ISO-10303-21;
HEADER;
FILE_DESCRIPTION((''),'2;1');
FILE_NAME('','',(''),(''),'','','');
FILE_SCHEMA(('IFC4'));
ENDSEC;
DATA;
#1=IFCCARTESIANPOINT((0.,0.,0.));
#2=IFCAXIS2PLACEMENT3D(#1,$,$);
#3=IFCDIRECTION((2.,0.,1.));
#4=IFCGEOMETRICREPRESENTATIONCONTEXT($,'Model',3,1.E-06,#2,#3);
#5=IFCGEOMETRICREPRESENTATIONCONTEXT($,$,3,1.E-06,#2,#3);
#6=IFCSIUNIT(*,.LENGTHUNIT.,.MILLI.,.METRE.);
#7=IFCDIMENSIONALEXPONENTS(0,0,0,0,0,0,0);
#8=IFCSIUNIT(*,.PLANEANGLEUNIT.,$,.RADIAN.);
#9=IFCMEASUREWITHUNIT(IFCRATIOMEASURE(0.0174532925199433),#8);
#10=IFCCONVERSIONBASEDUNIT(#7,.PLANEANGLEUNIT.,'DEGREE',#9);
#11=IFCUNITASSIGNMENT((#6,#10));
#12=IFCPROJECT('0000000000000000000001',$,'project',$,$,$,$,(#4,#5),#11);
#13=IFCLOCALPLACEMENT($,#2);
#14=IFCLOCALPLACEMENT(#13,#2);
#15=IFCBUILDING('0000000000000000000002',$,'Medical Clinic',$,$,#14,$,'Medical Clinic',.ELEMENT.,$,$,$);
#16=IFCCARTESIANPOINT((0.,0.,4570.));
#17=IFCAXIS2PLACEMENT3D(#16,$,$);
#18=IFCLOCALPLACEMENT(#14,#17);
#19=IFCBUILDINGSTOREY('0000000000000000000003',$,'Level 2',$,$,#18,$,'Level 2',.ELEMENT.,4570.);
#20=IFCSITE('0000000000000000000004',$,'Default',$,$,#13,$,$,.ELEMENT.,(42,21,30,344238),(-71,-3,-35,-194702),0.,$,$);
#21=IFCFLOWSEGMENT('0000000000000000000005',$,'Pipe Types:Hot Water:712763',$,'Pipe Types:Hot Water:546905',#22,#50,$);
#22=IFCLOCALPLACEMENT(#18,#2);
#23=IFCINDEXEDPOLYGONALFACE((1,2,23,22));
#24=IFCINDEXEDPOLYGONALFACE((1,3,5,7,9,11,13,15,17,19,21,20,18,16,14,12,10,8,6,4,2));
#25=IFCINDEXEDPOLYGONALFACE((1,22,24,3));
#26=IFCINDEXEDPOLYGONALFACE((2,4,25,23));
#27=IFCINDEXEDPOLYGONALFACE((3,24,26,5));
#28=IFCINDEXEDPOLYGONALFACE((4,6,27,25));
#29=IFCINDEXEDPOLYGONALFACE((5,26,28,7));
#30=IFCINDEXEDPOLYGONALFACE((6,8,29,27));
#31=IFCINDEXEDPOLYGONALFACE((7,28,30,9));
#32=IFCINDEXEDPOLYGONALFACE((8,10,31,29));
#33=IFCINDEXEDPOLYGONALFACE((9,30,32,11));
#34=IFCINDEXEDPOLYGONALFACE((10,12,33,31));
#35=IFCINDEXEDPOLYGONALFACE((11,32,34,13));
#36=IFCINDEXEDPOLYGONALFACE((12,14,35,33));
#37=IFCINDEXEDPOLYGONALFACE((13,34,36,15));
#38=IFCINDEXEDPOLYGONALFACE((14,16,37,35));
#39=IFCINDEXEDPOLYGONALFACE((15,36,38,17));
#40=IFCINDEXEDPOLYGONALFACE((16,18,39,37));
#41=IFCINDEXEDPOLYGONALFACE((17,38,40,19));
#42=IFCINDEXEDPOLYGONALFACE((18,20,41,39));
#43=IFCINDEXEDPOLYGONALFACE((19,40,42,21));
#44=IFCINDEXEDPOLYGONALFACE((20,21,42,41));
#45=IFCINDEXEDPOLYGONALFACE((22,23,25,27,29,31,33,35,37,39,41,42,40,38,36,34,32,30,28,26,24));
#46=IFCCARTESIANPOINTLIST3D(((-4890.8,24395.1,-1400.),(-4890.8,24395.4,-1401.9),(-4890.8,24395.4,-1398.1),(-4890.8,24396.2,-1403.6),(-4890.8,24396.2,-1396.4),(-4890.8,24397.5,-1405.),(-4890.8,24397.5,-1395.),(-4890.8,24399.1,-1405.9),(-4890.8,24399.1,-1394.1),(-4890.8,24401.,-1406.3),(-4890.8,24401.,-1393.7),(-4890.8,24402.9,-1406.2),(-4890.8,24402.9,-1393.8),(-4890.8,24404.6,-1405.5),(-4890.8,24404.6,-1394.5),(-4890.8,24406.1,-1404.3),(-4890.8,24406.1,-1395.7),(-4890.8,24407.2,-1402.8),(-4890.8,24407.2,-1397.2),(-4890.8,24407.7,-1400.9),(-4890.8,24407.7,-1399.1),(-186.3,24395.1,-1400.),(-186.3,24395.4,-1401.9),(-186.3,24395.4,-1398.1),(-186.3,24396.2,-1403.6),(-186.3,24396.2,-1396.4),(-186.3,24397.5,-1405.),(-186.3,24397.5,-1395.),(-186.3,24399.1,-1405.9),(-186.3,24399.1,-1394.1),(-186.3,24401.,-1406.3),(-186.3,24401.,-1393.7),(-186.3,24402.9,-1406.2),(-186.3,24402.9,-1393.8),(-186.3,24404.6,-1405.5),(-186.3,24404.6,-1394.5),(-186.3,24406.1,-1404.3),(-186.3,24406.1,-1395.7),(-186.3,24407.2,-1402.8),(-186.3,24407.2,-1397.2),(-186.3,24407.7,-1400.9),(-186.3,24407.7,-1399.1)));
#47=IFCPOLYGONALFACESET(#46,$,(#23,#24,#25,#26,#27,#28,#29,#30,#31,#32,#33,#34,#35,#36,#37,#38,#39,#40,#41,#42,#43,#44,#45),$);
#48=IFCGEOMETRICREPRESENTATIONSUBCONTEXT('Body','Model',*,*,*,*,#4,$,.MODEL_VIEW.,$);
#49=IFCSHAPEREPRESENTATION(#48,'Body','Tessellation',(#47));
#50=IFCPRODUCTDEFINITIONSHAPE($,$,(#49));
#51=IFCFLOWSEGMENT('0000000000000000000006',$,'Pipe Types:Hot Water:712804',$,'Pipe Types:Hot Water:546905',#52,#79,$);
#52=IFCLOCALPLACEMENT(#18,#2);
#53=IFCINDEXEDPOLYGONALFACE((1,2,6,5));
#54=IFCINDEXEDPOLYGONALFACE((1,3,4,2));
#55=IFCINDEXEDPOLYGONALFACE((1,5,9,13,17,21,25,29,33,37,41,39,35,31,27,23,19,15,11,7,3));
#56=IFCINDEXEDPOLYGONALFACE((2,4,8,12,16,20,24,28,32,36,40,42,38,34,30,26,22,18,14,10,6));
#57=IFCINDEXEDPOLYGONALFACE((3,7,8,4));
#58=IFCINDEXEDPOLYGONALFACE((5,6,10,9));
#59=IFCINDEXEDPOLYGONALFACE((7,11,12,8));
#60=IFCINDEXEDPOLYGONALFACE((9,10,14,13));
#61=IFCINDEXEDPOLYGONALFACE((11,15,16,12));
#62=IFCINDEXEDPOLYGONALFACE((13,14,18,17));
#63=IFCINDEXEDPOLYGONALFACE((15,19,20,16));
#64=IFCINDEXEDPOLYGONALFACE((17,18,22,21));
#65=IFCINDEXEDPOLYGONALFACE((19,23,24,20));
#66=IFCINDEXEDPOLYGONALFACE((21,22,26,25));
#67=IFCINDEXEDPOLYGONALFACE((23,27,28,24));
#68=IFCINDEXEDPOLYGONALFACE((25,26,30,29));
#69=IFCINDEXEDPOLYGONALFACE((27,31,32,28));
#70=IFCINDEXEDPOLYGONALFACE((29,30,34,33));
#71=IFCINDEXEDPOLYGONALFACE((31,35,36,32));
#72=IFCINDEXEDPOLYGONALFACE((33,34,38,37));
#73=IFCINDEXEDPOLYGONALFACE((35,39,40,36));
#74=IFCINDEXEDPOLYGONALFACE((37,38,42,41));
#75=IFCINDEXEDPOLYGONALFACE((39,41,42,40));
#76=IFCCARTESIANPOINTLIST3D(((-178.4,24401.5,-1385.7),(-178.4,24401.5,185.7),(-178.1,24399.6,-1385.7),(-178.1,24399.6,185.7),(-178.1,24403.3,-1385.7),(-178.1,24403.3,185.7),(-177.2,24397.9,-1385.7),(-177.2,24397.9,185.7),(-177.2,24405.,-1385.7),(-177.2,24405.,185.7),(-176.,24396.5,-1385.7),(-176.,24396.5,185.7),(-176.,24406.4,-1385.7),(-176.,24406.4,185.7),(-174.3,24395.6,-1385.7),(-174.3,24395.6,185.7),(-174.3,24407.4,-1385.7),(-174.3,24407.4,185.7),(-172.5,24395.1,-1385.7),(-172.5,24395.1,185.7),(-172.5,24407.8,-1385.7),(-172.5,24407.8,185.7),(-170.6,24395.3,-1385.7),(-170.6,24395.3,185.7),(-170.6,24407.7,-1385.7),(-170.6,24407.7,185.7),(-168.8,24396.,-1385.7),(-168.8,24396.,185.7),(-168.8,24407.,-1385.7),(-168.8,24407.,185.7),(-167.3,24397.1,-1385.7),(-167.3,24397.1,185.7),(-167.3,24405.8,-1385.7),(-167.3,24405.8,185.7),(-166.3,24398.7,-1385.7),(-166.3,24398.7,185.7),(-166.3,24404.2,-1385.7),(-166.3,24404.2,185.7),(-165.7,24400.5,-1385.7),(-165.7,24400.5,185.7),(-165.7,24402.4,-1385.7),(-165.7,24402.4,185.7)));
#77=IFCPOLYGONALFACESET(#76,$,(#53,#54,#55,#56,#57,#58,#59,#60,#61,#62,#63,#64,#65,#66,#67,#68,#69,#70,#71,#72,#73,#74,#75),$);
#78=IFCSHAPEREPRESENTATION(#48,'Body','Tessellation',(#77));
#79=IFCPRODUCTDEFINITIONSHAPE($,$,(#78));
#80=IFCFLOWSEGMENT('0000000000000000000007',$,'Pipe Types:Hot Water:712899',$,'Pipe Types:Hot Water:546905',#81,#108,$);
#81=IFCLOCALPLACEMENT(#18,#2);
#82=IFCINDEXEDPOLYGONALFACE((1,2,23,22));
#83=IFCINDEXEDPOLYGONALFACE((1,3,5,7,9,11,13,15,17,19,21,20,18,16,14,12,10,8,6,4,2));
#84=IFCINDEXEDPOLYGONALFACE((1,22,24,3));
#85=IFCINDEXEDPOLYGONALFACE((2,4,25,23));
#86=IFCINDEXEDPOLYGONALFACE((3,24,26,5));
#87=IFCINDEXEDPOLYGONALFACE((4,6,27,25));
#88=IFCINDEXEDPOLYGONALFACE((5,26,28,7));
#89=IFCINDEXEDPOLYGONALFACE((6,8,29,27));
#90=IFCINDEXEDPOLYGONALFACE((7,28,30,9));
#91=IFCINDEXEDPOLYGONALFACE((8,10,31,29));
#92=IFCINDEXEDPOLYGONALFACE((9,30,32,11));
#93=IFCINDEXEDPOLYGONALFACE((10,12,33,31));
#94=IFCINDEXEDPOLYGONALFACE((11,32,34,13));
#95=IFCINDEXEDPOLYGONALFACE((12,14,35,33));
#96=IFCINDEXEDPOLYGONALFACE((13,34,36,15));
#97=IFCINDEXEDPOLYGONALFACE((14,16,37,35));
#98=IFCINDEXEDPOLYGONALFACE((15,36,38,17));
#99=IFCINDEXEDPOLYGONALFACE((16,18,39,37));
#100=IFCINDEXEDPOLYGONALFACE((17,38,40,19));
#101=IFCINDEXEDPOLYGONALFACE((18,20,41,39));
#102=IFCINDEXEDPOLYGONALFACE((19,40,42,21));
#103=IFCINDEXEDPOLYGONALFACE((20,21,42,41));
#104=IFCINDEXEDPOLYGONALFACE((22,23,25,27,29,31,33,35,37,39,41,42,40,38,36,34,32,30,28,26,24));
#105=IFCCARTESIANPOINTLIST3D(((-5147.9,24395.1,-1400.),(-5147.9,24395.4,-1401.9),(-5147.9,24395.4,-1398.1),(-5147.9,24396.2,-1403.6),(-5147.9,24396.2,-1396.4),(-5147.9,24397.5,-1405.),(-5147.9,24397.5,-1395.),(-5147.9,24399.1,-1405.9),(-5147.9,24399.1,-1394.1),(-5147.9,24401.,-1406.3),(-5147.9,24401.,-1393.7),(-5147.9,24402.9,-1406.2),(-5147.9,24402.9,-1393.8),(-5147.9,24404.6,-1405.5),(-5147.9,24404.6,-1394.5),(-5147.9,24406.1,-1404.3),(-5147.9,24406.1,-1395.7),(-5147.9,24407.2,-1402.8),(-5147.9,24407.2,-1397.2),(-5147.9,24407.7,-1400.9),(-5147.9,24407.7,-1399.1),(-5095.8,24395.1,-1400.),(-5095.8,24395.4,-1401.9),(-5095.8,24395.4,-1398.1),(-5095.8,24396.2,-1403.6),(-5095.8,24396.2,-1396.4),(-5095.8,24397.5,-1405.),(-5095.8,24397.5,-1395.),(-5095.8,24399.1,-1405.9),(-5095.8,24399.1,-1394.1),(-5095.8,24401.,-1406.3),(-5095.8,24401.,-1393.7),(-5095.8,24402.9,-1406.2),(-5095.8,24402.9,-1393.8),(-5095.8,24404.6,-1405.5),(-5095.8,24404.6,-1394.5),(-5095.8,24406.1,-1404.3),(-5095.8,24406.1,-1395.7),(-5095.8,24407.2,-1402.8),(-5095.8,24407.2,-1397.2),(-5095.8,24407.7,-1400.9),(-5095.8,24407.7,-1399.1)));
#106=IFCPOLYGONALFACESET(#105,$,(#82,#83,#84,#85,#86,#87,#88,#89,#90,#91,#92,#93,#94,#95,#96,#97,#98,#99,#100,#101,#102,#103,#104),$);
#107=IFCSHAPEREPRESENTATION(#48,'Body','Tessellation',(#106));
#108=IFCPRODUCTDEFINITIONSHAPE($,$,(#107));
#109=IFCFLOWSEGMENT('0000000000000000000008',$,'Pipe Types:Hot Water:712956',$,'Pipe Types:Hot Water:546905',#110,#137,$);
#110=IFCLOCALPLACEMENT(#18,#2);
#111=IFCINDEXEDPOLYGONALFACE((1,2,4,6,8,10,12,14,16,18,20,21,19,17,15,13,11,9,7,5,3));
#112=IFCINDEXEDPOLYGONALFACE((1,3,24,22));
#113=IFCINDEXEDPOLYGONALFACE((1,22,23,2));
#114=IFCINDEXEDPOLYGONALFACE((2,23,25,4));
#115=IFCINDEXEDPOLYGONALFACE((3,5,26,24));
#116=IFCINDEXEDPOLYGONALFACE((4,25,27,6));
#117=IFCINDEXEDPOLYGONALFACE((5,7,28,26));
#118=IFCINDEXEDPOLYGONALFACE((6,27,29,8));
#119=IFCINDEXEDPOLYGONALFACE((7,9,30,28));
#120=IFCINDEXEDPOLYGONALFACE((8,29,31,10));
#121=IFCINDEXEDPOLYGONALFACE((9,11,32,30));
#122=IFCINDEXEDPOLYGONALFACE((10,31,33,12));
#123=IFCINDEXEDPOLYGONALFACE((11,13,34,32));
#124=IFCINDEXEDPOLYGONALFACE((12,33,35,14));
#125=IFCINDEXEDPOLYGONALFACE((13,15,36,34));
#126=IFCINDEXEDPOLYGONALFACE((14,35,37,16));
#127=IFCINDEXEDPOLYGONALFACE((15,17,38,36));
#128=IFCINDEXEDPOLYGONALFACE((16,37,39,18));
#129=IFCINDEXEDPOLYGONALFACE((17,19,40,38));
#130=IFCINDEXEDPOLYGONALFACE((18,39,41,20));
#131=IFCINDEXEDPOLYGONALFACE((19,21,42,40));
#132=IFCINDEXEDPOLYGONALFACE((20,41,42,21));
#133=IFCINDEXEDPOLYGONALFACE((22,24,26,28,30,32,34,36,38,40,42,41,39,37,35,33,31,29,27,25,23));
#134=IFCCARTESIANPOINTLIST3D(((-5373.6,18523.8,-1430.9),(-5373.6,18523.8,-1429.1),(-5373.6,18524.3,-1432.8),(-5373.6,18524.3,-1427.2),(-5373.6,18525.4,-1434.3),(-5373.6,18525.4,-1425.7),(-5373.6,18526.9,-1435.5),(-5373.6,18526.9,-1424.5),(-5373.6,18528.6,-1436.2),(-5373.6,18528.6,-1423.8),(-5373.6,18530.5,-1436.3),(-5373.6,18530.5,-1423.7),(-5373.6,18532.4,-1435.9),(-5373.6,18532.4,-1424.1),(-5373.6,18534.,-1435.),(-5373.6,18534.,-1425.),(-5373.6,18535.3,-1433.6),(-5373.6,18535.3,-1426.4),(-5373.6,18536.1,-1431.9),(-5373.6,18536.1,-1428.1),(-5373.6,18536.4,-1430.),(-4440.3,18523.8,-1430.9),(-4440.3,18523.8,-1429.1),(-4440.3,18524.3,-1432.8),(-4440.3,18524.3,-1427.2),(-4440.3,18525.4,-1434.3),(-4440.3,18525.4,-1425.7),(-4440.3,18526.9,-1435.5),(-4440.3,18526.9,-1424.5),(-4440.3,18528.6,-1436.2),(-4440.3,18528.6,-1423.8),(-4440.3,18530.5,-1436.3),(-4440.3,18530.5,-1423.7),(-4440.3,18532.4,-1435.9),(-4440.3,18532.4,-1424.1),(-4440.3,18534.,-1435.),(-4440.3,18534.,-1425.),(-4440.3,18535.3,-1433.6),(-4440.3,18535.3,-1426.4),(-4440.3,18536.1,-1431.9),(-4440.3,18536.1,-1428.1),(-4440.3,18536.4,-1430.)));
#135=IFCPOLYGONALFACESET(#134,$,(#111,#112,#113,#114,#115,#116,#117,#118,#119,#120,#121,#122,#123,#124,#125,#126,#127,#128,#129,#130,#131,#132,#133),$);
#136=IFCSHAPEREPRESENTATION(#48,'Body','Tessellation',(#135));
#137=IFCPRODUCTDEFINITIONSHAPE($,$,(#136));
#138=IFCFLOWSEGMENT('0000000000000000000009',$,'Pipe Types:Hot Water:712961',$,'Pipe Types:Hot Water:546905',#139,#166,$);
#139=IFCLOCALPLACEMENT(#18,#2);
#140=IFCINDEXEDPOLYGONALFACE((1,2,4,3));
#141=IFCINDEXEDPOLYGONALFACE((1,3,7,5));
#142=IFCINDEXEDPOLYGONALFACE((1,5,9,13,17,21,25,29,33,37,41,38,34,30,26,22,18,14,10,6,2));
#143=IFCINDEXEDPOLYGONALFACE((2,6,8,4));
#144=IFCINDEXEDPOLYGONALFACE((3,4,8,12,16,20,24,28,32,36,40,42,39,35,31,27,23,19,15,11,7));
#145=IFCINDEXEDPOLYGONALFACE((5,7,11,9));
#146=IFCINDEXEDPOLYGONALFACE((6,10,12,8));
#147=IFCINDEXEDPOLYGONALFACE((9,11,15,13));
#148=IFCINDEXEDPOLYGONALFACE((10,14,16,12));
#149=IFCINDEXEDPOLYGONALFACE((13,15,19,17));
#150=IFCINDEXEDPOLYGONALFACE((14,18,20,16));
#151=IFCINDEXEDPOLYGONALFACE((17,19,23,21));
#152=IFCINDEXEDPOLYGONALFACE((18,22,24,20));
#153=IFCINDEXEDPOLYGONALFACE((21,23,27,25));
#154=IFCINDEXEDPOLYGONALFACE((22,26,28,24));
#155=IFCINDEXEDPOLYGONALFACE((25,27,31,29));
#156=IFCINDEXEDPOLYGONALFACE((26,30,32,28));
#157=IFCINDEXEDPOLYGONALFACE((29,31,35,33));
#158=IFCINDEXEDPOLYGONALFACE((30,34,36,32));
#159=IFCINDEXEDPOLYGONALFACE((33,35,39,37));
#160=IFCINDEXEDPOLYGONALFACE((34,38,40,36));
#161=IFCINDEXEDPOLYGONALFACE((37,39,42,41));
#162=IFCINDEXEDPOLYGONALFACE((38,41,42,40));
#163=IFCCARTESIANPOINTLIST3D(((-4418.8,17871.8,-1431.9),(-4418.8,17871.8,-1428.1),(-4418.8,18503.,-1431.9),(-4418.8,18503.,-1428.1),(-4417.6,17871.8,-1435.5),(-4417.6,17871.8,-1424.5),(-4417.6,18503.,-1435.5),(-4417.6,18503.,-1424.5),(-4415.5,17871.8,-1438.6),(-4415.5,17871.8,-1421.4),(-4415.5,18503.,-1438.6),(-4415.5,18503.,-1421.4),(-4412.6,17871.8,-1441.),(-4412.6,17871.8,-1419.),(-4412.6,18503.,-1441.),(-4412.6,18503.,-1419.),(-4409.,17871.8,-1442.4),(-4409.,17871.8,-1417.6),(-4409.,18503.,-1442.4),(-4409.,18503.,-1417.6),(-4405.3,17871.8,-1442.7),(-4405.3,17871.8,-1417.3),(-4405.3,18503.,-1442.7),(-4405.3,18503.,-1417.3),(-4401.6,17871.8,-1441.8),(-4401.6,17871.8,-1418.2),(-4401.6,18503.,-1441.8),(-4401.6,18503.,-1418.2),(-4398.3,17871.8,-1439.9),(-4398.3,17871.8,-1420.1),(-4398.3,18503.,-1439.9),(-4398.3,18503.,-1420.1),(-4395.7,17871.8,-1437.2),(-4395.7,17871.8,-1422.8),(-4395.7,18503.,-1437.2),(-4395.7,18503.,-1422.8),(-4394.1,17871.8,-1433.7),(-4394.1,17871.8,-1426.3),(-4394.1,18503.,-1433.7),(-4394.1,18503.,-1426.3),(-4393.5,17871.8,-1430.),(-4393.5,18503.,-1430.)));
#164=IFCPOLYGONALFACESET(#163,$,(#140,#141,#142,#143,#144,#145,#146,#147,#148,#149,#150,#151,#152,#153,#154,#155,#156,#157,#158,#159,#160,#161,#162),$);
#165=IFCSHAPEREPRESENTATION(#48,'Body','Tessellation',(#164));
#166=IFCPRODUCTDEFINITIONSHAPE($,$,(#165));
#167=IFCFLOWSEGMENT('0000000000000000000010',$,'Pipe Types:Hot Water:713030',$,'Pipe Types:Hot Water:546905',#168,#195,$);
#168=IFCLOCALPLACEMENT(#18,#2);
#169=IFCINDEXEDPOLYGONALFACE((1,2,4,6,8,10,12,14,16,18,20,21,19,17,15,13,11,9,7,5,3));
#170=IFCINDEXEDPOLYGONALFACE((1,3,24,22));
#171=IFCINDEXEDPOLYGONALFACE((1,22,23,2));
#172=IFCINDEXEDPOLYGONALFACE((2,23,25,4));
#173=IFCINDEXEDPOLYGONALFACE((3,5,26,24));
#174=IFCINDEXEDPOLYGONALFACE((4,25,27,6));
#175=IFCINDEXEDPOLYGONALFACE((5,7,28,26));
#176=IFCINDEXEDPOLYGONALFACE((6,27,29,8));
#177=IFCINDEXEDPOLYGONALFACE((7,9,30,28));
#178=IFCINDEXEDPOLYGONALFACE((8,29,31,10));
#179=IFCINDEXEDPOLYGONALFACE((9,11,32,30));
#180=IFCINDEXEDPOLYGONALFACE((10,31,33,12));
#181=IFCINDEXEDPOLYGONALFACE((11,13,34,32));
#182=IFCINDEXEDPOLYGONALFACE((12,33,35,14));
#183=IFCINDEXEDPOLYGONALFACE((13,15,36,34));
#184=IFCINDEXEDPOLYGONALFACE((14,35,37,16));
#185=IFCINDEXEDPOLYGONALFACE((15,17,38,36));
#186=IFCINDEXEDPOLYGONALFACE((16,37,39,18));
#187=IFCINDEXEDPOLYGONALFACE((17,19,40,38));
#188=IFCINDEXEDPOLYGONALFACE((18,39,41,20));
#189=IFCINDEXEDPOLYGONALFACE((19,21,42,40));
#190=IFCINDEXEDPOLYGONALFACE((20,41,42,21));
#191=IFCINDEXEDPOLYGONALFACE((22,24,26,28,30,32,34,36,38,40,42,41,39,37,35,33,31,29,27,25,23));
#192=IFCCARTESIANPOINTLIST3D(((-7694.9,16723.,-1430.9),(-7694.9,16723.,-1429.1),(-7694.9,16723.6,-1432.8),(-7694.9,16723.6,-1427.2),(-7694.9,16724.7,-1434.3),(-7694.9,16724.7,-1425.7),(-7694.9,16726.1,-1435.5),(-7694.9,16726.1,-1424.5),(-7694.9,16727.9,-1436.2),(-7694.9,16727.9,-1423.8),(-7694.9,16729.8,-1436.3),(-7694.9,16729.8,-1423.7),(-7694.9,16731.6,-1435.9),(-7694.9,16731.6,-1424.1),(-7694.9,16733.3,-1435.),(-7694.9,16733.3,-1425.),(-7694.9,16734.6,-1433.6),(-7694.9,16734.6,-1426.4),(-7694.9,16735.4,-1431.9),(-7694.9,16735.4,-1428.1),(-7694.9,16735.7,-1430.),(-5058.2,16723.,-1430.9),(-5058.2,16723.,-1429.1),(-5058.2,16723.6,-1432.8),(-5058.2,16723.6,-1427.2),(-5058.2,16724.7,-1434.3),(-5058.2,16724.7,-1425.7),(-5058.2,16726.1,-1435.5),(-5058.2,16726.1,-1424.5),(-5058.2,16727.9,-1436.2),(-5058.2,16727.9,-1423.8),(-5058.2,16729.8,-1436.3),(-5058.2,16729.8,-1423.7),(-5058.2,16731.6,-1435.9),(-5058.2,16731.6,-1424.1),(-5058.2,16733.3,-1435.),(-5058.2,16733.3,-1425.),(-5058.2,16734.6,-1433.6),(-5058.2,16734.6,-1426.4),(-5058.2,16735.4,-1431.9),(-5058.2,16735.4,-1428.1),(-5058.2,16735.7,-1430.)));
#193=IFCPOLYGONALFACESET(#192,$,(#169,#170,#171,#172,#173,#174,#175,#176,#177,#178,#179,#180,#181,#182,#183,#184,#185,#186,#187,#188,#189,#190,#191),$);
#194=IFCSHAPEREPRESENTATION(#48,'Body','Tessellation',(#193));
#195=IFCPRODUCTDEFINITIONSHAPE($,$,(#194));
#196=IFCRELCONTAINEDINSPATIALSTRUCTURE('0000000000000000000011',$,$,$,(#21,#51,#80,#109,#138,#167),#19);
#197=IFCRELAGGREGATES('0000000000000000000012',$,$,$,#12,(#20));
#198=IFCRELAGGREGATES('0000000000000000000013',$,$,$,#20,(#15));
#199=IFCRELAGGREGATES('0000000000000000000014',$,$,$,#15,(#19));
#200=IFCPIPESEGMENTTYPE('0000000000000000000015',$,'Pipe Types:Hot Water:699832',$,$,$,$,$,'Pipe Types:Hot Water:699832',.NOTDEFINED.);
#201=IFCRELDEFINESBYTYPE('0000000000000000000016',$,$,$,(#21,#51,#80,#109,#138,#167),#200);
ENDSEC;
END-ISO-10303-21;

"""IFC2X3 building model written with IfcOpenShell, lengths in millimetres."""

from ifc_helpers import new_model, entity, si_unit, converted_unit, direction, frame, frame_2d, origin, origin_2d_with_axis, place, context, subcontext, project, spatial, circle, extrude, type_object, element, save


model = new_model("IFC2X3")

# Units and contexts
model_context = context("Model", 3, precision=1e-06, world=origin(), true_north=direction((2.0, 0.0, 1.0)))
context_of_model = context(None, 3, precision=1e-06, world=origin(), true_north=direction((2.0, 0.0, 1.0)))
body_context = subcontext(model_context, "Body", "Model", "MODEL_VIEW")
ifc_project = project(units=[si_unit("LENGTHUNIT", "METRE", prefix="MILLI"), converted_unit("PLANEANGLEUNIT", "DEGREE", entity("IfcRatioMeasure", 0.0174532925199433), si_unit("PLANEANGLEUNIT", "RADIAN"), dimensions=[0, 0, 0, 0, 0, 0, 0])], contexts=[model_context, context_of_model])

# Site, building, storey
site_placement = place(None, origin())
site = spatial("IfcSite", under=ifc_project, at=site_placement, Name="Default", CompositionType="ELEMENT", RefLatitude=(42, 21, 30, 344238), RefLongitude=(-71, -3, -35, -194702), RefElevation=0.0)
building_placement = place(site_placement, origin())
building = spatial("IfcBuilding", under=site, at=building_placement, Name="Medical Clinic", LongName="Medical Clinic", CompositionType="ELEMENT")
storey_placement = place(building_placement, frame((0.0, 0.0, 4570.0)))
storey = spatial("IfcBuildingStorey", under=building, at=storey_placement, Name="Level 2", LongName="Level 2", CompositionType="ELEMENT", Elevation=4570.0)

# Flow segments
pipe_segment_type_1 = type_object("IfcPipeSegmentType", Name="Pipe Types:Hot Water:699832", ElementType="Pipe Types:Hot Water:699832", PredefinedType="NOTDEFINED")
flow_segment_1_placement = place(storey_placement, origin())
element("IfcFlowSegment", 1, at=flow_segment_1_placement, inside=storey, type_object=pipe_segment_type_1, Name="Pipe Types:Hot Water:712763", ObjectType="Pipe Types:Hot Water:546905", context=body_context, shape_type="SweptSolid", body=[
    extrude(circle(Radius=6.3, at=origin_2d_with_axis()), frame((-4890.8, 24401.5, -1400.0), z_axis=(1.0, 0.0, 0.0), x_axis=(0.0, -1.0, 0.0)), (0.0, 0.0, 1.0), 4704.5),
])
flow_segment_2_placement = place(storey_placement, origin())
element("IfcFlowSegment", 2, at=flow_segment_2_placement, inside=storey, type_object=pipe_segment_type_1, Name="Pipe Types:Hot Water:712804", ObjectType="Pipe Types:Hot Water:546905", context=body_context, shape_type="SweptSolid", body=[
    extrude(circle(Radius=6.3, at=frame_2d((0.0, 0.0), x_axis=(1.0, 0.0))), frame((-172.0, 24401.5, -1385.7), z_axis=(0.0, 0.0, 1.0), x_axis=(-1.0, 0.0, 0.0)), (0.0, 0.0, 1.0), 1571.4),
])
flow_segment_3_placement = place(storey_placement, origin())
element("IfcFlowSegment", 3, at=flow_segment_3_placement, inside=storey, type_object=pipe_segment_type_1, Name="Pipe Types:Hot Water:712899", ObjectType="Pipe Types:Hot Water:546905", context=body_context, shape_type="SweptSolid", body=[
    extrude(circle(Radius=6.3, at=origin_2d_with_axis()), frame((-5147.9, 24401.5, -1400.0), z_axis=(1.0, 0.0, 0.0), x_axis=(0.0, -1.0, 0.0)), (0.0, 0.0, 1.0), 52.1),
])
flow_segment_4_placement = place(storey_placement, origin())
element("IfcFlowSegment", 4, at=flow_segment_4_placement, inside=storey, type_object=pipe_segment_type_1, Name="Pipe Types:Hot Water:712956", ObjectType="Pipe Types:Hot Water:546905", context=body_context, shape_type="SweptSolid", body=[
    extrude(circle(Radius=6.3, at=origin_2d_with_axis()), frame((-5373.6, 18530.0, -1430.0), z_axis=(1.0, 0.0, 0.0), x_axis=(0.0, 1.0, 0.0)), (0.0, 0.0, 1.0), 933.2),
])
flow_segment_5_placement = place(storey_placement, origin())
element("IfcFlowSegment", 5, at=flow_segment_5_placement, inside=storey, type_object=pipe_segment_type_1, Name="Pipe Types:Hot Water:712961", ObjectType="Pipe Types:Hot Water:546905", context=body_context, shape_type="SweptSolid", body=[
    extrude(circle(Radius=12.7, at=origin_2d_with_axis()), frame((-4406.2, 17871.8, -1430.0), z_axis=(0.0, 1.0, 0.0), x_axis=(1.0, 0.0, 0.0)), (0.0, 0.0, 1.0), 631.3),
])
flow_segment_6_placement = place(storey_placement, origin())
element("IfcFlowSegment", 6, at=flow_segment_6_placement, inside=storey, type_object=pipe_segment_type_1, Name="Pipe Types:Hot Water:713030", ObjectType="Pipe Types:Hot Water:546905", context=body_context, shape_type="SweptSolid", body=[
    extrude(circle(Radius=6.3, at=frame_2d((0.0, 0.0), x_axis=(1.0, 0.0))), frame((-7694.9, 16729.3, -1430.0), z_axis=(1.0, 0.0, 0.0), x_axis=(0.0, 1.0, 0.0)), (0.0, 0.0, 1.0), 2636.7),
])

save(model, "model.ifc")
